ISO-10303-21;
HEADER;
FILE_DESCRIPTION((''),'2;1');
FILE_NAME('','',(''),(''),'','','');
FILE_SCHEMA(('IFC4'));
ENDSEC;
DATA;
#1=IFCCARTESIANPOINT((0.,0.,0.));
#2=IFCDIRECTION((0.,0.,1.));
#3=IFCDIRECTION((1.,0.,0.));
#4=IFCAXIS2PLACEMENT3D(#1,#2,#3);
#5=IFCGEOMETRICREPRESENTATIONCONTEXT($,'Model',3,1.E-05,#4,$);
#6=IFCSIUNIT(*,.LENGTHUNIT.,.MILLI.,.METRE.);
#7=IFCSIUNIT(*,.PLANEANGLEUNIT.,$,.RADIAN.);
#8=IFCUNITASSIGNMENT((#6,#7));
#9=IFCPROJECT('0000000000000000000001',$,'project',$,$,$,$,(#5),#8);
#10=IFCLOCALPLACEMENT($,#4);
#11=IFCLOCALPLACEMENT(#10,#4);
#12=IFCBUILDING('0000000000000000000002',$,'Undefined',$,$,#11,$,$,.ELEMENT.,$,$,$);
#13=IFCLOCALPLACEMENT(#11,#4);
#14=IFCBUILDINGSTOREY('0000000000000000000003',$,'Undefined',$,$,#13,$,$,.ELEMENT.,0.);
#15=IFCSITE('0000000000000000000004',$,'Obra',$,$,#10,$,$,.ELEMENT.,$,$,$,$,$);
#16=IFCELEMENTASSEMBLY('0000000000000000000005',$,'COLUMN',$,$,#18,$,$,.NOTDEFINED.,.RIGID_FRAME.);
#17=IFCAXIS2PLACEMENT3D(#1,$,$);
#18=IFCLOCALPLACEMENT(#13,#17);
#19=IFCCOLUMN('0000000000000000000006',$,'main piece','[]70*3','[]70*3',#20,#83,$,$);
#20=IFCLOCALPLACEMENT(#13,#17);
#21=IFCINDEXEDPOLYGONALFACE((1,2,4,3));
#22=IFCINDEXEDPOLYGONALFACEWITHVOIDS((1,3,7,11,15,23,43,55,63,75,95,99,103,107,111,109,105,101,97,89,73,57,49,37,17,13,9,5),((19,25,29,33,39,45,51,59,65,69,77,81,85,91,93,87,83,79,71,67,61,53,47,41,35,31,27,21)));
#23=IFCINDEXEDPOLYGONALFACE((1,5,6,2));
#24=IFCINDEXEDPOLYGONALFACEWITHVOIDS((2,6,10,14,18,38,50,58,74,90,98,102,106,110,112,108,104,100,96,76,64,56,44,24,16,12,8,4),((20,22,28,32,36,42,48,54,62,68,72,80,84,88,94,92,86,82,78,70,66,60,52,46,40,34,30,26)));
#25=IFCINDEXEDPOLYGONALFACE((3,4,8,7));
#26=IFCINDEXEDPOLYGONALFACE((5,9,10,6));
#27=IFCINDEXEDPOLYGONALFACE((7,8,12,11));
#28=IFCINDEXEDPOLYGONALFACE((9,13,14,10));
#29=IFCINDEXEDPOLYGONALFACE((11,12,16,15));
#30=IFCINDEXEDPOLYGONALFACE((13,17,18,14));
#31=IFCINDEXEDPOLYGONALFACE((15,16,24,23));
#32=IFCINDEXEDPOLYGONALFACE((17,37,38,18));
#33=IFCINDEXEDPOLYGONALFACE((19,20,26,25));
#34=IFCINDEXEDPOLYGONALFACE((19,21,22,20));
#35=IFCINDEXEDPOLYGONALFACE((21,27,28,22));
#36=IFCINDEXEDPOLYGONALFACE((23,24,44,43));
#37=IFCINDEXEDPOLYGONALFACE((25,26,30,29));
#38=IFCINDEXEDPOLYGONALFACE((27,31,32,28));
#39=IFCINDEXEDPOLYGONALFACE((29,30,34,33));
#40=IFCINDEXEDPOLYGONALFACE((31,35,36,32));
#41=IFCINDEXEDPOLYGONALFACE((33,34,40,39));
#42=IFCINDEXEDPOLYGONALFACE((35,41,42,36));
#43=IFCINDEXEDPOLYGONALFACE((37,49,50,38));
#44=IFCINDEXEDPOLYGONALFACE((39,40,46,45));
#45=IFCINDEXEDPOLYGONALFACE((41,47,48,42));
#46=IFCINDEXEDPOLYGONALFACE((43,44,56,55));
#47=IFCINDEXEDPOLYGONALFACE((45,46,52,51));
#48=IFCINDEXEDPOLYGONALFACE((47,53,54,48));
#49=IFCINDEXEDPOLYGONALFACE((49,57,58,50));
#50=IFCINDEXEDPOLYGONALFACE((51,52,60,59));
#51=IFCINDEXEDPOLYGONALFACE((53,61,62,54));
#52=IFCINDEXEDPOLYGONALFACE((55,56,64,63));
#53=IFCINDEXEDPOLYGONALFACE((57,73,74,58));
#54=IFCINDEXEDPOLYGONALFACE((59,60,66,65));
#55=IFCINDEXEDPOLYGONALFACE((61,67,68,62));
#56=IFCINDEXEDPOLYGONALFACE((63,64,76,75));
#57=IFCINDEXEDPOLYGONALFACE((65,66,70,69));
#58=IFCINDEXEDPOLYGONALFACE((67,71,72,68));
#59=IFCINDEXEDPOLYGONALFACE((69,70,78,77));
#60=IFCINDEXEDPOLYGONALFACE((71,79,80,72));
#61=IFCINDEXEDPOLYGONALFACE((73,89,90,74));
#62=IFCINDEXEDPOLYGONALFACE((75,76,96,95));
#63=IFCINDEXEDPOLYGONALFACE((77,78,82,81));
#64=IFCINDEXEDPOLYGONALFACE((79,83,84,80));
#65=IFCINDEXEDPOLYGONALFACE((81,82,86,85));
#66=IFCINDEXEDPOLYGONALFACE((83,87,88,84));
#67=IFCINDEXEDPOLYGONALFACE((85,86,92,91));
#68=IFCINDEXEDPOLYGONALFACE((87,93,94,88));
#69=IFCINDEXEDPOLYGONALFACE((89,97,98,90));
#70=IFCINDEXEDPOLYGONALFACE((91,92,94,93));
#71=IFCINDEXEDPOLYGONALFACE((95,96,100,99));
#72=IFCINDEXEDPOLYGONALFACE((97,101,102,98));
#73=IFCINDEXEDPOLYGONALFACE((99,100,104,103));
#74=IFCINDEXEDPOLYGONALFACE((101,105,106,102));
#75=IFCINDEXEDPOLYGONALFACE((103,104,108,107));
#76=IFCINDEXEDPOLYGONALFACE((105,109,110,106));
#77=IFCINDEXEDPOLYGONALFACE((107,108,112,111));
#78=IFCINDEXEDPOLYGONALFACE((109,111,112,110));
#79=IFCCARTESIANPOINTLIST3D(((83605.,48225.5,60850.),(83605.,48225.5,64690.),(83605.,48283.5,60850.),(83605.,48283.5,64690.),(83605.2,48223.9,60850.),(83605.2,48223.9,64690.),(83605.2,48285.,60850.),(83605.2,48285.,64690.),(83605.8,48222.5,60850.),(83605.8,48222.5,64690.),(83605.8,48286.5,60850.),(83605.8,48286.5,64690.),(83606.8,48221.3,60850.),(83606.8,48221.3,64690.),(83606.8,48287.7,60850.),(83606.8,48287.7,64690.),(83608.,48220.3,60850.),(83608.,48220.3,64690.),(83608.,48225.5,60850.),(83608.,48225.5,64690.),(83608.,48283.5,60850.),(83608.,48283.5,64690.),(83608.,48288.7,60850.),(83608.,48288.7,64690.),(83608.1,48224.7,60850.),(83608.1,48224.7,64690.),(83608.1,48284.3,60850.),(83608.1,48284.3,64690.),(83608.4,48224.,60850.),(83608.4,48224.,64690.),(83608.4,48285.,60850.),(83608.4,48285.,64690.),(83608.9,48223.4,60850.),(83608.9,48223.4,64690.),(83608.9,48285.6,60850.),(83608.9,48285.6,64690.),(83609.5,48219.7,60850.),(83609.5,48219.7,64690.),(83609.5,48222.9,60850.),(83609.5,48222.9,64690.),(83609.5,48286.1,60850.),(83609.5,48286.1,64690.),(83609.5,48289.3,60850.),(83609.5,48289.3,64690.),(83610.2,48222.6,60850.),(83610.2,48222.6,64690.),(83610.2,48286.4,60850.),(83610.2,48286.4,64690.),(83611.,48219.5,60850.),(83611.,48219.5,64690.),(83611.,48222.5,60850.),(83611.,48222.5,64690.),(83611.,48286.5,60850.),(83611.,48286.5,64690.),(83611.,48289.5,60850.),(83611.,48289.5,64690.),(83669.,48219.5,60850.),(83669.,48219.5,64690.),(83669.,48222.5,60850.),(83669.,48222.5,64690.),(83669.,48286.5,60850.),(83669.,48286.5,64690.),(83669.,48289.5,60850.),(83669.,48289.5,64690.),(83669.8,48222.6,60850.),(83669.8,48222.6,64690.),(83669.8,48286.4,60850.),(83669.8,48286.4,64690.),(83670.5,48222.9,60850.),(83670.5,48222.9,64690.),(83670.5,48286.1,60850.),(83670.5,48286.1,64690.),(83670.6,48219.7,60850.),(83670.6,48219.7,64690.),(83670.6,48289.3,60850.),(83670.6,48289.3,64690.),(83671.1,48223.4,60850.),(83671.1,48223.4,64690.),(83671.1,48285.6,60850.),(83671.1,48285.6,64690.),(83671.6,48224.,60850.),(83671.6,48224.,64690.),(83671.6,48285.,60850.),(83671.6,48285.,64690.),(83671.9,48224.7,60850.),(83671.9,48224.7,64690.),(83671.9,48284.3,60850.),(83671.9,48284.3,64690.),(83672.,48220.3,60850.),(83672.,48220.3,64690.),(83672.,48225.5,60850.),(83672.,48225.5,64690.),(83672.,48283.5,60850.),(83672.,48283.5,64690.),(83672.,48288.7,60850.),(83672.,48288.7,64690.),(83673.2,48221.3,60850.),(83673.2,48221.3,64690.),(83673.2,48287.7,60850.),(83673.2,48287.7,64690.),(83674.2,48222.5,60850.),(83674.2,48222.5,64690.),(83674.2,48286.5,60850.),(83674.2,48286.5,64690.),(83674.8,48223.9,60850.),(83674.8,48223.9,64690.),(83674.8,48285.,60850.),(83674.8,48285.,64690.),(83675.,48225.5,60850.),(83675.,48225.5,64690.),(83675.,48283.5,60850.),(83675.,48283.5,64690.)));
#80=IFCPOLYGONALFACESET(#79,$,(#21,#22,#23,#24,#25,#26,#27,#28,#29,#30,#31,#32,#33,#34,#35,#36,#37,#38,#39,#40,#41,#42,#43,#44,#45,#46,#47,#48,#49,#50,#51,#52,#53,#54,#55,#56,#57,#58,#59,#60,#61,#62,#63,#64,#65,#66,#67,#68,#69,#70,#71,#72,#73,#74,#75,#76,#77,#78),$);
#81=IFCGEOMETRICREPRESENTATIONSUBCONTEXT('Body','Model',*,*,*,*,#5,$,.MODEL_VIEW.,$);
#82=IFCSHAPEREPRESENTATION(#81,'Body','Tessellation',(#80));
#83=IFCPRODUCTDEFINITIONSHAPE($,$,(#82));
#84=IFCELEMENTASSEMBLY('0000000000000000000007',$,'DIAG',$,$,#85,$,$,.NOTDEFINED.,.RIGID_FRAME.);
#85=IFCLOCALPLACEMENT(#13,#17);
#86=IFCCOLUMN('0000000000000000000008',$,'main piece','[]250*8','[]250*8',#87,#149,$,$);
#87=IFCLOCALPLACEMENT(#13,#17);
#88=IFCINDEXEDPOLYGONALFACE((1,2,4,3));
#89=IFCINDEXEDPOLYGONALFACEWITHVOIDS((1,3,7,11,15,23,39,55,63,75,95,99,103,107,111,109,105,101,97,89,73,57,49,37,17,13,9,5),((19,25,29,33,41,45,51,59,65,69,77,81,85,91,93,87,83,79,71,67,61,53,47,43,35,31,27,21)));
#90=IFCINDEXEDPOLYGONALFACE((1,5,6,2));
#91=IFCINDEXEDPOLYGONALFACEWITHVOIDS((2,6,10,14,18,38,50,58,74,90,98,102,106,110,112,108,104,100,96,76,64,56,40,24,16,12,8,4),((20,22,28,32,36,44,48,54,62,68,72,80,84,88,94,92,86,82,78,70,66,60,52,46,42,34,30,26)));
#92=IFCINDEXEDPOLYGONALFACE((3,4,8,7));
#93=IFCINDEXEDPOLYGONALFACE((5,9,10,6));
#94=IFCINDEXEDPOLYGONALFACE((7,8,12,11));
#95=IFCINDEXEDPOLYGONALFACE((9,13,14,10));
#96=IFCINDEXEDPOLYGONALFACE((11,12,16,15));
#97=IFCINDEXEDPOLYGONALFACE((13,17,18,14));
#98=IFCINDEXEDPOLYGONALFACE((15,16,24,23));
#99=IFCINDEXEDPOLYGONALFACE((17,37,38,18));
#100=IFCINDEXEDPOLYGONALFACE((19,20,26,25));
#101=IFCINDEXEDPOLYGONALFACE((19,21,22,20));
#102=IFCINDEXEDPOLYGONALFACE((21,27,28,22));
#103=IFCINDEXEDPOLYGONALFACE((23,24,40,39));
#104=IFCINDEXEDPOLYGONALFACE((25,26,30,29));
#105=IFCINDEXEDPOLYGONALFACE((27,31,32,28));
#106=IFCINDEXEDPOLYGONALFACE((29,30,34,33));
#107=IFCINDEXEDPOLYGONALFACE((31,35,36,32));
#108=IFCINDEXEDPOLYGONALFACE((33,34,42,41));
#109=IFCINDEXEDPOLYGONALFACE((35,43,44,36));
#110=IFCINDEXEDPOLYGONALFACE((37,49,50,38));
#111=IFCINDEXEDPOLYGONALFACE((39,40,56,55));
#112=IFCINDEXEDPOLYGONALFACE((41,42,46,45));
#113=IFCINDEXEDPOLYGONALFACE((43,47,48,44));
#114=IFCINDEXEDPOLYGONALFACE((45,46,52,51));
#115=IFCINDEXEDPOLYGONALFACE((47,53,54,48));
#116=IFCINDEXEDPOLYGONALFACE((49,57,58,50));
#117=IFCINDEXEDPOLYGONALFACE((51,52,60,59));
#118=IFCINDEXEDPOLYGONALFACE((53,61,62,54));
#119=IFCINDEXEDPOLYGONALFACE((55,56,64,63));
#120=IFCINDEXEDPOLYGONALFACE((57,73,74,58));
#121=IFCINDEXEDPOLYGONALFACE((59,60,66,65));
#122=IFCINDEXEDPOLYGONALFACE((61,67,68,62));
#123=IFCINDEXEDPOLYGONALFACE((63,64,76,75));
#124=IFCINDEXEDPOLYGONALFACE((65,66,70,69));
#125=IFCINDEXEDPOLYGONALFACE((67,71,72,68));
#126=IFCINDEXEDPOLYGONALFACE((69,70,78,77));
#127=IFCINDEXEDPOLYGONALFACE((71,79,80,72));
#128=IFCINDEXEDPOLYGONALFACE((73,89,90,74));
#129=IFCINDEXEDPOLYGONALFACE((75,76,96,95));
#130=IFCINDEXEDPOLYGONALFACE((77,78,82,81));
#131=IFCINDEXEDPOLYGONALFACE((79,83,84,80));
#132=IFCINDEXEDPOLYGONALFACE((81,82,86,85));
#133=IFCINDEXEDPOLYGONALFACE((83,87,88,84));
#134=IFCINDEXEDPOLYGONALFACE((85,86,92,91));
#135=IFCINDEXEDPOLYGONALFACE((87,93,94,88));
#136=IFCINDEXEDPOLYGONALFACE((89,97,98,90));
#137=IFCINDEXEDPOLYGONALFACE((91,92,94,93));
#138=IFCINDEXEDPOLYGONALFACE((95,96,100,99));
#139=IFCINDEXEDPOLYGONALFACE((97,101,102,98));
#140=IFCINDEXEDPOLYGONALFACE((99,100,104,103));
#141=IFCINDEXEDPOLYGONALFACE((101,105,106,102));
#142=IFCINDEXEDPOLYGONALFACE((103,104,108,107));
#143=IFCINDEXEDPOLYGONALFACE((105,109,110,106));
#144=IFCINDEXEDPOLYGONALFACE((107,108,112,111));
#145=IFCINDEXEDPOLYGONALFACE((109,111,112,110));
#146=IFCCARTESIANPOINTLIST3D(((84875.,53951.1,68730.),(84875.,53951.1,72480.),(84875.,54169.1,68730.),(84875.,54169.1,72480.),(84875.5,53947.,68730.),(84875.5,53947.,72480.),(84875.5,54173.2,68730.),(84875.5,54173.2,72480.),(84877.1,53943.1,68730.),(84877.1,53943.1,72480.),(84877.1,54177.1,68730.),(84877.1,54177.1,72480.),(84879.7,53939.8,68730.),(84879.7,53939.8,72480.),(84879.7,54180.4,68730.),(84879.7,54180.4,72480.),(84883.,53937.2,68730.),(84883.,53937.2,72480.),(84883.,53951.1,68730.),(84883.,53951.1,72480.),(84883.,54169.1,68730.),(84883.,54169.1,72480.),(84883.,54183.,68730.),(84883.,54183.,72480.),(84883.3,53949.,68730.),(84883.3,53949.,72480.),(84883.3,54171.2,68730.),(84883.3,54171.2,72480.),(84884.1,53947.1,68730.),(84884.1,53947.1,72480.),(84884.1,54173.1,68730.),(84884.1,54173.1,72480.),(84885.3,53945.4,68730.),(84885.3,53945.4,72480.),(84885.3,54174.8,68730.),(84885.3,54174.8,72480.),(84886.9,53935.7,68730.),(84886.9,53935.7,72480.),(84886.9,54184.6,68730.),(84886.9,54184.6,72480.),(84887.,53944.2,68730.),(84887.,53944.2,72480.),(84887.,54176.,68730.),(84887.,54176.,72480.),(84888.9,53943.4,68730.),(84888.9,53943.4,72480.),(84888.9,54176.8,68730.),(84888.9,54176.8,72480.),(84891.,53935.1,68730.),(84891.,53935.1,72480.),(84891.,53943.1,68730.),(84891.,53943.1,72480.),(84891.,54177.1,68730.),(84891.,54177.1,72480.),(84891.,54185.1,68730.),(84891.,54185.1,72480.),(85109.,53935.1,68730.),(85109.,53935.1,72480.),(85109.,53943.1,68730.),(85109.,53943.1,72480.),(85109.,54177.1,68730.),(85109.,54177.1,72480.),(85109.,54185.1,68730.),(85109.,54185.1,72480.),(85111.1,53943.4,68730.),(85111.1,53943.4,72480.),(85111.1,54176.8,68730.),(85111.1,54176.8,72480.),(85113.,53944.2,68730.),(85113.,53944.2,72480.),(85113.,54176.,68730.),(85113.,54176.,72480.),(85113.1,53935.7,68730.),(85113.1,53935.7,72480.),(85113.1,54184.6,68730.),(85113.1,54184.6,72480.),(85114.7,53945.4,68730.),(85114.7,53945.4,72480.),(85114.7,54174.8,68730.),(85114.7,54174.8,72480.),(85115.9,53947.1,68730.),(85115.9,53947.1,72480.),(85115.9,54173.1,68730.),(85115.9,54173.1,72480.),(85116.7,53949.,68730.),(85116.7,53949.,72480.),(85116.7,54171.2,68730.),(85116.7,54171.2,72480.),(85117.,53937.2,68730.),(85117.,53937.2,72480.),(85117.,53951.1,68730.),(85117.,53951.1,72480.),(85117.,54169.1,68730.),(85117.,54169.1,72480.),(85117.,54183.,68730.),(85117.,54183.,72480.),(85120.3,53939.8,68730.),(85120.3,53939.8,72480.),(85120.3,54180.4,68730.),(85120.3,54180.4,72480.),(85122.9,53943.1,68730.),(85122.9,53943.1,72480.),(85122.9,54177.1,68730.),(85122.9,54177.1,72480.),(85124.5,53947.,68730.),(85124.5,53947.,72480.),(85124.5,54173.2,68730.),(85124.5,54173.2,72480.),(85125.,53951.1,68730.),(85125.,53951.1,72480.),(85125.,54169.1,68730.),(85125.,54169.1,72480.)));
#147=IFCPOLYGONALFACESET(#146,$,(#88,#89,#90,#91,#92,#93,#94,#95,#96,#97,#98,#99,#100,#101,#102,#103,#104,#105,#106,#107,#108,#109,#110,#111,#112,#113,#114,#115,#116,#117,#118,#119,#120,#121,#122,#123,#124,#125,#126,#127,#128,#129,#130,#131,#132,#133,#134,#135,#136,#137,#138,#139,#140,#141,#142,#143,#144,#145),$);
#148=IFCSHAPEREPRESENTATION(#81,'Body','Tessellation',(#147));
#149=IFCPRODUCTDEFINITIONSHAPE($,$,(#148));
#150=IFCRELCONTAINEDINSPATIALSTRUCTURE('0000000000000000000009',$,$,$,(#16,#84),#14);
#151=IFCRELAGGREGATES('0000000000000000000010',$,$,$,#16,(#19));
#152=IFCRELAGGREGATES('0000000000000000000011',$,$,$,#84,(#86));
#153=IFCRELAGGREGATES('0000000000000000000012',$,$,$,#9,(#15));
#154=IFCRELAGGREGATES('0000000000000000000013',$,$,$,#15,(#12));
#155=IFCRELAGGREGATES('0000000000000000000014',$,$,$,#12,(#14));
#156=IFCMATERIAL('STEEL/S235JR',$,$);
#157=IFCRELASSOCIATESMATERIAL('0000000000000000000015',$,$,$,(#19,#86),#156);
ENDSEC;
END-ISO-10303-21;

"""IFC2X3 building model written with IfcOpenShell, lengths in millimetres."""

from ifc_helpers import new_model, si_unit, frame, origin_with_axes, origin_2d_with_axis, place, context, subcontext, project, spatial, hollow_rectangle, extrude, material, element, aggregate, save


model = new_model("IFC2X3")

# Units and contexts
model_context = context("Model", 3, precision=1e-05, world=origin_with_axes())
body_context = subcontext(model_context, "Body", "Model", "MODEL_VIEW")
ifc_project = project(units=[si_unit("LENGTHUNIT", "METRE", prefix="MILLI"), si_unit("PLANEANGLEUNIT", "RADIAN")], contexts=[model_context])

# Site, building, storey
site_placement = place(None, origin_with_axes())
site = spatial("IfcSite", under=ifc_project, at=site_placement, Name="Obra", CompositionType="ELEMENT")
building_placement = place(site_placement, origin_with_axes())
building = spatial("IfcBuilding", under=site, at=building_placement, Name="Undefined", CompositionType="ELEMENT")
storey_placement = place(building_placement, origin_with_axes())
storey = spatial("IfcBuildingStorey", under=building, at=storey_placement, Name="Undefined", CompositionType="ELEMENT", Elevation=0.0)

# Element assemblies, columns
ifc_material = material(Name="STEEL/S235JR")
assembly_1_placement = place(storey_placement, origin_with_axes())
assembly_1 = element("IfcElementAssembly", 1, at=assembly_1_placement, inside=storey, Name="COLUMN", AssemblyPlace="NOTDEFINED", PredefinedType="RIGID_FRAME")
column_1_placement = place(assembly_1_placement, frame((83640.0, 48254.5, 60850.0), z_axis=(0.0, 0.0, 1.0), x_axis=(0.0, 1.0, 0.0)))
column_1 = element("IfcColumn", 2, at=column_1_placement, material=ifc_material, Name="main piece", Description="[]70*3", ObjectType="[]70*3", context=body_context, shape_type="SweptSolid", body=[
    extrude(hollow_rectangle(XDim=70.0, YDim=70.0, WallThickness=3.0, InnerFilletRadius=3.0, OuterFilletRadius=6.0, at=origin_2d_with_axis()), frame((0.0, 0.0, 3840.0), z_axis=(0.0, 0.0, -1.0), x_axis=(0.0, 1.0, 0.0)), (0.0, 0.0, 1.0), 3840.0),
])
aggregate(assembly_1, [column_1])
assembly_2_placement = place(storey_placement, origin_with_axes())
assembly_2 = element("IfcElementAssembly", 3, at=assembly_2_placement, inside=storey, Name="DIAG", AssemblyPlace="NOTDEFINED", PredefinedType="RIGID_FRAME")
column_2_placement = place(assembly_2_placement, frame((85000.0, 54060.1, 68730.0), z_axis=(0.0, 0.0, 1.0), x_axis=(-1.0, 0.0, 0.0)))
column_2 = element("IfcColumn", 4, at=column_2_placement, material=ifc_material, Name="main piece", Description="[]250*8", ObjectType="[]250*8", context=body_context, shape_type="SweptSolid", body=[
    extrude(hollow_rectangle(XDim=250.0, YDim=250.0, WallThickness=8.0, InnerFilletRadius=8.0, OuterFilletRadius=16.0, at=origin_2d_with_axis()), frame((0.0, 0.0, 3750.0), z_axis=(0.0, 0.0, -1.0), x_axis=(0.0, 1.0, 0.0)), (0.0, 0.0, 1.0), 3750.0),
])
aggregate(assembly_2, [column_2])

save(model, "model.ifc")
